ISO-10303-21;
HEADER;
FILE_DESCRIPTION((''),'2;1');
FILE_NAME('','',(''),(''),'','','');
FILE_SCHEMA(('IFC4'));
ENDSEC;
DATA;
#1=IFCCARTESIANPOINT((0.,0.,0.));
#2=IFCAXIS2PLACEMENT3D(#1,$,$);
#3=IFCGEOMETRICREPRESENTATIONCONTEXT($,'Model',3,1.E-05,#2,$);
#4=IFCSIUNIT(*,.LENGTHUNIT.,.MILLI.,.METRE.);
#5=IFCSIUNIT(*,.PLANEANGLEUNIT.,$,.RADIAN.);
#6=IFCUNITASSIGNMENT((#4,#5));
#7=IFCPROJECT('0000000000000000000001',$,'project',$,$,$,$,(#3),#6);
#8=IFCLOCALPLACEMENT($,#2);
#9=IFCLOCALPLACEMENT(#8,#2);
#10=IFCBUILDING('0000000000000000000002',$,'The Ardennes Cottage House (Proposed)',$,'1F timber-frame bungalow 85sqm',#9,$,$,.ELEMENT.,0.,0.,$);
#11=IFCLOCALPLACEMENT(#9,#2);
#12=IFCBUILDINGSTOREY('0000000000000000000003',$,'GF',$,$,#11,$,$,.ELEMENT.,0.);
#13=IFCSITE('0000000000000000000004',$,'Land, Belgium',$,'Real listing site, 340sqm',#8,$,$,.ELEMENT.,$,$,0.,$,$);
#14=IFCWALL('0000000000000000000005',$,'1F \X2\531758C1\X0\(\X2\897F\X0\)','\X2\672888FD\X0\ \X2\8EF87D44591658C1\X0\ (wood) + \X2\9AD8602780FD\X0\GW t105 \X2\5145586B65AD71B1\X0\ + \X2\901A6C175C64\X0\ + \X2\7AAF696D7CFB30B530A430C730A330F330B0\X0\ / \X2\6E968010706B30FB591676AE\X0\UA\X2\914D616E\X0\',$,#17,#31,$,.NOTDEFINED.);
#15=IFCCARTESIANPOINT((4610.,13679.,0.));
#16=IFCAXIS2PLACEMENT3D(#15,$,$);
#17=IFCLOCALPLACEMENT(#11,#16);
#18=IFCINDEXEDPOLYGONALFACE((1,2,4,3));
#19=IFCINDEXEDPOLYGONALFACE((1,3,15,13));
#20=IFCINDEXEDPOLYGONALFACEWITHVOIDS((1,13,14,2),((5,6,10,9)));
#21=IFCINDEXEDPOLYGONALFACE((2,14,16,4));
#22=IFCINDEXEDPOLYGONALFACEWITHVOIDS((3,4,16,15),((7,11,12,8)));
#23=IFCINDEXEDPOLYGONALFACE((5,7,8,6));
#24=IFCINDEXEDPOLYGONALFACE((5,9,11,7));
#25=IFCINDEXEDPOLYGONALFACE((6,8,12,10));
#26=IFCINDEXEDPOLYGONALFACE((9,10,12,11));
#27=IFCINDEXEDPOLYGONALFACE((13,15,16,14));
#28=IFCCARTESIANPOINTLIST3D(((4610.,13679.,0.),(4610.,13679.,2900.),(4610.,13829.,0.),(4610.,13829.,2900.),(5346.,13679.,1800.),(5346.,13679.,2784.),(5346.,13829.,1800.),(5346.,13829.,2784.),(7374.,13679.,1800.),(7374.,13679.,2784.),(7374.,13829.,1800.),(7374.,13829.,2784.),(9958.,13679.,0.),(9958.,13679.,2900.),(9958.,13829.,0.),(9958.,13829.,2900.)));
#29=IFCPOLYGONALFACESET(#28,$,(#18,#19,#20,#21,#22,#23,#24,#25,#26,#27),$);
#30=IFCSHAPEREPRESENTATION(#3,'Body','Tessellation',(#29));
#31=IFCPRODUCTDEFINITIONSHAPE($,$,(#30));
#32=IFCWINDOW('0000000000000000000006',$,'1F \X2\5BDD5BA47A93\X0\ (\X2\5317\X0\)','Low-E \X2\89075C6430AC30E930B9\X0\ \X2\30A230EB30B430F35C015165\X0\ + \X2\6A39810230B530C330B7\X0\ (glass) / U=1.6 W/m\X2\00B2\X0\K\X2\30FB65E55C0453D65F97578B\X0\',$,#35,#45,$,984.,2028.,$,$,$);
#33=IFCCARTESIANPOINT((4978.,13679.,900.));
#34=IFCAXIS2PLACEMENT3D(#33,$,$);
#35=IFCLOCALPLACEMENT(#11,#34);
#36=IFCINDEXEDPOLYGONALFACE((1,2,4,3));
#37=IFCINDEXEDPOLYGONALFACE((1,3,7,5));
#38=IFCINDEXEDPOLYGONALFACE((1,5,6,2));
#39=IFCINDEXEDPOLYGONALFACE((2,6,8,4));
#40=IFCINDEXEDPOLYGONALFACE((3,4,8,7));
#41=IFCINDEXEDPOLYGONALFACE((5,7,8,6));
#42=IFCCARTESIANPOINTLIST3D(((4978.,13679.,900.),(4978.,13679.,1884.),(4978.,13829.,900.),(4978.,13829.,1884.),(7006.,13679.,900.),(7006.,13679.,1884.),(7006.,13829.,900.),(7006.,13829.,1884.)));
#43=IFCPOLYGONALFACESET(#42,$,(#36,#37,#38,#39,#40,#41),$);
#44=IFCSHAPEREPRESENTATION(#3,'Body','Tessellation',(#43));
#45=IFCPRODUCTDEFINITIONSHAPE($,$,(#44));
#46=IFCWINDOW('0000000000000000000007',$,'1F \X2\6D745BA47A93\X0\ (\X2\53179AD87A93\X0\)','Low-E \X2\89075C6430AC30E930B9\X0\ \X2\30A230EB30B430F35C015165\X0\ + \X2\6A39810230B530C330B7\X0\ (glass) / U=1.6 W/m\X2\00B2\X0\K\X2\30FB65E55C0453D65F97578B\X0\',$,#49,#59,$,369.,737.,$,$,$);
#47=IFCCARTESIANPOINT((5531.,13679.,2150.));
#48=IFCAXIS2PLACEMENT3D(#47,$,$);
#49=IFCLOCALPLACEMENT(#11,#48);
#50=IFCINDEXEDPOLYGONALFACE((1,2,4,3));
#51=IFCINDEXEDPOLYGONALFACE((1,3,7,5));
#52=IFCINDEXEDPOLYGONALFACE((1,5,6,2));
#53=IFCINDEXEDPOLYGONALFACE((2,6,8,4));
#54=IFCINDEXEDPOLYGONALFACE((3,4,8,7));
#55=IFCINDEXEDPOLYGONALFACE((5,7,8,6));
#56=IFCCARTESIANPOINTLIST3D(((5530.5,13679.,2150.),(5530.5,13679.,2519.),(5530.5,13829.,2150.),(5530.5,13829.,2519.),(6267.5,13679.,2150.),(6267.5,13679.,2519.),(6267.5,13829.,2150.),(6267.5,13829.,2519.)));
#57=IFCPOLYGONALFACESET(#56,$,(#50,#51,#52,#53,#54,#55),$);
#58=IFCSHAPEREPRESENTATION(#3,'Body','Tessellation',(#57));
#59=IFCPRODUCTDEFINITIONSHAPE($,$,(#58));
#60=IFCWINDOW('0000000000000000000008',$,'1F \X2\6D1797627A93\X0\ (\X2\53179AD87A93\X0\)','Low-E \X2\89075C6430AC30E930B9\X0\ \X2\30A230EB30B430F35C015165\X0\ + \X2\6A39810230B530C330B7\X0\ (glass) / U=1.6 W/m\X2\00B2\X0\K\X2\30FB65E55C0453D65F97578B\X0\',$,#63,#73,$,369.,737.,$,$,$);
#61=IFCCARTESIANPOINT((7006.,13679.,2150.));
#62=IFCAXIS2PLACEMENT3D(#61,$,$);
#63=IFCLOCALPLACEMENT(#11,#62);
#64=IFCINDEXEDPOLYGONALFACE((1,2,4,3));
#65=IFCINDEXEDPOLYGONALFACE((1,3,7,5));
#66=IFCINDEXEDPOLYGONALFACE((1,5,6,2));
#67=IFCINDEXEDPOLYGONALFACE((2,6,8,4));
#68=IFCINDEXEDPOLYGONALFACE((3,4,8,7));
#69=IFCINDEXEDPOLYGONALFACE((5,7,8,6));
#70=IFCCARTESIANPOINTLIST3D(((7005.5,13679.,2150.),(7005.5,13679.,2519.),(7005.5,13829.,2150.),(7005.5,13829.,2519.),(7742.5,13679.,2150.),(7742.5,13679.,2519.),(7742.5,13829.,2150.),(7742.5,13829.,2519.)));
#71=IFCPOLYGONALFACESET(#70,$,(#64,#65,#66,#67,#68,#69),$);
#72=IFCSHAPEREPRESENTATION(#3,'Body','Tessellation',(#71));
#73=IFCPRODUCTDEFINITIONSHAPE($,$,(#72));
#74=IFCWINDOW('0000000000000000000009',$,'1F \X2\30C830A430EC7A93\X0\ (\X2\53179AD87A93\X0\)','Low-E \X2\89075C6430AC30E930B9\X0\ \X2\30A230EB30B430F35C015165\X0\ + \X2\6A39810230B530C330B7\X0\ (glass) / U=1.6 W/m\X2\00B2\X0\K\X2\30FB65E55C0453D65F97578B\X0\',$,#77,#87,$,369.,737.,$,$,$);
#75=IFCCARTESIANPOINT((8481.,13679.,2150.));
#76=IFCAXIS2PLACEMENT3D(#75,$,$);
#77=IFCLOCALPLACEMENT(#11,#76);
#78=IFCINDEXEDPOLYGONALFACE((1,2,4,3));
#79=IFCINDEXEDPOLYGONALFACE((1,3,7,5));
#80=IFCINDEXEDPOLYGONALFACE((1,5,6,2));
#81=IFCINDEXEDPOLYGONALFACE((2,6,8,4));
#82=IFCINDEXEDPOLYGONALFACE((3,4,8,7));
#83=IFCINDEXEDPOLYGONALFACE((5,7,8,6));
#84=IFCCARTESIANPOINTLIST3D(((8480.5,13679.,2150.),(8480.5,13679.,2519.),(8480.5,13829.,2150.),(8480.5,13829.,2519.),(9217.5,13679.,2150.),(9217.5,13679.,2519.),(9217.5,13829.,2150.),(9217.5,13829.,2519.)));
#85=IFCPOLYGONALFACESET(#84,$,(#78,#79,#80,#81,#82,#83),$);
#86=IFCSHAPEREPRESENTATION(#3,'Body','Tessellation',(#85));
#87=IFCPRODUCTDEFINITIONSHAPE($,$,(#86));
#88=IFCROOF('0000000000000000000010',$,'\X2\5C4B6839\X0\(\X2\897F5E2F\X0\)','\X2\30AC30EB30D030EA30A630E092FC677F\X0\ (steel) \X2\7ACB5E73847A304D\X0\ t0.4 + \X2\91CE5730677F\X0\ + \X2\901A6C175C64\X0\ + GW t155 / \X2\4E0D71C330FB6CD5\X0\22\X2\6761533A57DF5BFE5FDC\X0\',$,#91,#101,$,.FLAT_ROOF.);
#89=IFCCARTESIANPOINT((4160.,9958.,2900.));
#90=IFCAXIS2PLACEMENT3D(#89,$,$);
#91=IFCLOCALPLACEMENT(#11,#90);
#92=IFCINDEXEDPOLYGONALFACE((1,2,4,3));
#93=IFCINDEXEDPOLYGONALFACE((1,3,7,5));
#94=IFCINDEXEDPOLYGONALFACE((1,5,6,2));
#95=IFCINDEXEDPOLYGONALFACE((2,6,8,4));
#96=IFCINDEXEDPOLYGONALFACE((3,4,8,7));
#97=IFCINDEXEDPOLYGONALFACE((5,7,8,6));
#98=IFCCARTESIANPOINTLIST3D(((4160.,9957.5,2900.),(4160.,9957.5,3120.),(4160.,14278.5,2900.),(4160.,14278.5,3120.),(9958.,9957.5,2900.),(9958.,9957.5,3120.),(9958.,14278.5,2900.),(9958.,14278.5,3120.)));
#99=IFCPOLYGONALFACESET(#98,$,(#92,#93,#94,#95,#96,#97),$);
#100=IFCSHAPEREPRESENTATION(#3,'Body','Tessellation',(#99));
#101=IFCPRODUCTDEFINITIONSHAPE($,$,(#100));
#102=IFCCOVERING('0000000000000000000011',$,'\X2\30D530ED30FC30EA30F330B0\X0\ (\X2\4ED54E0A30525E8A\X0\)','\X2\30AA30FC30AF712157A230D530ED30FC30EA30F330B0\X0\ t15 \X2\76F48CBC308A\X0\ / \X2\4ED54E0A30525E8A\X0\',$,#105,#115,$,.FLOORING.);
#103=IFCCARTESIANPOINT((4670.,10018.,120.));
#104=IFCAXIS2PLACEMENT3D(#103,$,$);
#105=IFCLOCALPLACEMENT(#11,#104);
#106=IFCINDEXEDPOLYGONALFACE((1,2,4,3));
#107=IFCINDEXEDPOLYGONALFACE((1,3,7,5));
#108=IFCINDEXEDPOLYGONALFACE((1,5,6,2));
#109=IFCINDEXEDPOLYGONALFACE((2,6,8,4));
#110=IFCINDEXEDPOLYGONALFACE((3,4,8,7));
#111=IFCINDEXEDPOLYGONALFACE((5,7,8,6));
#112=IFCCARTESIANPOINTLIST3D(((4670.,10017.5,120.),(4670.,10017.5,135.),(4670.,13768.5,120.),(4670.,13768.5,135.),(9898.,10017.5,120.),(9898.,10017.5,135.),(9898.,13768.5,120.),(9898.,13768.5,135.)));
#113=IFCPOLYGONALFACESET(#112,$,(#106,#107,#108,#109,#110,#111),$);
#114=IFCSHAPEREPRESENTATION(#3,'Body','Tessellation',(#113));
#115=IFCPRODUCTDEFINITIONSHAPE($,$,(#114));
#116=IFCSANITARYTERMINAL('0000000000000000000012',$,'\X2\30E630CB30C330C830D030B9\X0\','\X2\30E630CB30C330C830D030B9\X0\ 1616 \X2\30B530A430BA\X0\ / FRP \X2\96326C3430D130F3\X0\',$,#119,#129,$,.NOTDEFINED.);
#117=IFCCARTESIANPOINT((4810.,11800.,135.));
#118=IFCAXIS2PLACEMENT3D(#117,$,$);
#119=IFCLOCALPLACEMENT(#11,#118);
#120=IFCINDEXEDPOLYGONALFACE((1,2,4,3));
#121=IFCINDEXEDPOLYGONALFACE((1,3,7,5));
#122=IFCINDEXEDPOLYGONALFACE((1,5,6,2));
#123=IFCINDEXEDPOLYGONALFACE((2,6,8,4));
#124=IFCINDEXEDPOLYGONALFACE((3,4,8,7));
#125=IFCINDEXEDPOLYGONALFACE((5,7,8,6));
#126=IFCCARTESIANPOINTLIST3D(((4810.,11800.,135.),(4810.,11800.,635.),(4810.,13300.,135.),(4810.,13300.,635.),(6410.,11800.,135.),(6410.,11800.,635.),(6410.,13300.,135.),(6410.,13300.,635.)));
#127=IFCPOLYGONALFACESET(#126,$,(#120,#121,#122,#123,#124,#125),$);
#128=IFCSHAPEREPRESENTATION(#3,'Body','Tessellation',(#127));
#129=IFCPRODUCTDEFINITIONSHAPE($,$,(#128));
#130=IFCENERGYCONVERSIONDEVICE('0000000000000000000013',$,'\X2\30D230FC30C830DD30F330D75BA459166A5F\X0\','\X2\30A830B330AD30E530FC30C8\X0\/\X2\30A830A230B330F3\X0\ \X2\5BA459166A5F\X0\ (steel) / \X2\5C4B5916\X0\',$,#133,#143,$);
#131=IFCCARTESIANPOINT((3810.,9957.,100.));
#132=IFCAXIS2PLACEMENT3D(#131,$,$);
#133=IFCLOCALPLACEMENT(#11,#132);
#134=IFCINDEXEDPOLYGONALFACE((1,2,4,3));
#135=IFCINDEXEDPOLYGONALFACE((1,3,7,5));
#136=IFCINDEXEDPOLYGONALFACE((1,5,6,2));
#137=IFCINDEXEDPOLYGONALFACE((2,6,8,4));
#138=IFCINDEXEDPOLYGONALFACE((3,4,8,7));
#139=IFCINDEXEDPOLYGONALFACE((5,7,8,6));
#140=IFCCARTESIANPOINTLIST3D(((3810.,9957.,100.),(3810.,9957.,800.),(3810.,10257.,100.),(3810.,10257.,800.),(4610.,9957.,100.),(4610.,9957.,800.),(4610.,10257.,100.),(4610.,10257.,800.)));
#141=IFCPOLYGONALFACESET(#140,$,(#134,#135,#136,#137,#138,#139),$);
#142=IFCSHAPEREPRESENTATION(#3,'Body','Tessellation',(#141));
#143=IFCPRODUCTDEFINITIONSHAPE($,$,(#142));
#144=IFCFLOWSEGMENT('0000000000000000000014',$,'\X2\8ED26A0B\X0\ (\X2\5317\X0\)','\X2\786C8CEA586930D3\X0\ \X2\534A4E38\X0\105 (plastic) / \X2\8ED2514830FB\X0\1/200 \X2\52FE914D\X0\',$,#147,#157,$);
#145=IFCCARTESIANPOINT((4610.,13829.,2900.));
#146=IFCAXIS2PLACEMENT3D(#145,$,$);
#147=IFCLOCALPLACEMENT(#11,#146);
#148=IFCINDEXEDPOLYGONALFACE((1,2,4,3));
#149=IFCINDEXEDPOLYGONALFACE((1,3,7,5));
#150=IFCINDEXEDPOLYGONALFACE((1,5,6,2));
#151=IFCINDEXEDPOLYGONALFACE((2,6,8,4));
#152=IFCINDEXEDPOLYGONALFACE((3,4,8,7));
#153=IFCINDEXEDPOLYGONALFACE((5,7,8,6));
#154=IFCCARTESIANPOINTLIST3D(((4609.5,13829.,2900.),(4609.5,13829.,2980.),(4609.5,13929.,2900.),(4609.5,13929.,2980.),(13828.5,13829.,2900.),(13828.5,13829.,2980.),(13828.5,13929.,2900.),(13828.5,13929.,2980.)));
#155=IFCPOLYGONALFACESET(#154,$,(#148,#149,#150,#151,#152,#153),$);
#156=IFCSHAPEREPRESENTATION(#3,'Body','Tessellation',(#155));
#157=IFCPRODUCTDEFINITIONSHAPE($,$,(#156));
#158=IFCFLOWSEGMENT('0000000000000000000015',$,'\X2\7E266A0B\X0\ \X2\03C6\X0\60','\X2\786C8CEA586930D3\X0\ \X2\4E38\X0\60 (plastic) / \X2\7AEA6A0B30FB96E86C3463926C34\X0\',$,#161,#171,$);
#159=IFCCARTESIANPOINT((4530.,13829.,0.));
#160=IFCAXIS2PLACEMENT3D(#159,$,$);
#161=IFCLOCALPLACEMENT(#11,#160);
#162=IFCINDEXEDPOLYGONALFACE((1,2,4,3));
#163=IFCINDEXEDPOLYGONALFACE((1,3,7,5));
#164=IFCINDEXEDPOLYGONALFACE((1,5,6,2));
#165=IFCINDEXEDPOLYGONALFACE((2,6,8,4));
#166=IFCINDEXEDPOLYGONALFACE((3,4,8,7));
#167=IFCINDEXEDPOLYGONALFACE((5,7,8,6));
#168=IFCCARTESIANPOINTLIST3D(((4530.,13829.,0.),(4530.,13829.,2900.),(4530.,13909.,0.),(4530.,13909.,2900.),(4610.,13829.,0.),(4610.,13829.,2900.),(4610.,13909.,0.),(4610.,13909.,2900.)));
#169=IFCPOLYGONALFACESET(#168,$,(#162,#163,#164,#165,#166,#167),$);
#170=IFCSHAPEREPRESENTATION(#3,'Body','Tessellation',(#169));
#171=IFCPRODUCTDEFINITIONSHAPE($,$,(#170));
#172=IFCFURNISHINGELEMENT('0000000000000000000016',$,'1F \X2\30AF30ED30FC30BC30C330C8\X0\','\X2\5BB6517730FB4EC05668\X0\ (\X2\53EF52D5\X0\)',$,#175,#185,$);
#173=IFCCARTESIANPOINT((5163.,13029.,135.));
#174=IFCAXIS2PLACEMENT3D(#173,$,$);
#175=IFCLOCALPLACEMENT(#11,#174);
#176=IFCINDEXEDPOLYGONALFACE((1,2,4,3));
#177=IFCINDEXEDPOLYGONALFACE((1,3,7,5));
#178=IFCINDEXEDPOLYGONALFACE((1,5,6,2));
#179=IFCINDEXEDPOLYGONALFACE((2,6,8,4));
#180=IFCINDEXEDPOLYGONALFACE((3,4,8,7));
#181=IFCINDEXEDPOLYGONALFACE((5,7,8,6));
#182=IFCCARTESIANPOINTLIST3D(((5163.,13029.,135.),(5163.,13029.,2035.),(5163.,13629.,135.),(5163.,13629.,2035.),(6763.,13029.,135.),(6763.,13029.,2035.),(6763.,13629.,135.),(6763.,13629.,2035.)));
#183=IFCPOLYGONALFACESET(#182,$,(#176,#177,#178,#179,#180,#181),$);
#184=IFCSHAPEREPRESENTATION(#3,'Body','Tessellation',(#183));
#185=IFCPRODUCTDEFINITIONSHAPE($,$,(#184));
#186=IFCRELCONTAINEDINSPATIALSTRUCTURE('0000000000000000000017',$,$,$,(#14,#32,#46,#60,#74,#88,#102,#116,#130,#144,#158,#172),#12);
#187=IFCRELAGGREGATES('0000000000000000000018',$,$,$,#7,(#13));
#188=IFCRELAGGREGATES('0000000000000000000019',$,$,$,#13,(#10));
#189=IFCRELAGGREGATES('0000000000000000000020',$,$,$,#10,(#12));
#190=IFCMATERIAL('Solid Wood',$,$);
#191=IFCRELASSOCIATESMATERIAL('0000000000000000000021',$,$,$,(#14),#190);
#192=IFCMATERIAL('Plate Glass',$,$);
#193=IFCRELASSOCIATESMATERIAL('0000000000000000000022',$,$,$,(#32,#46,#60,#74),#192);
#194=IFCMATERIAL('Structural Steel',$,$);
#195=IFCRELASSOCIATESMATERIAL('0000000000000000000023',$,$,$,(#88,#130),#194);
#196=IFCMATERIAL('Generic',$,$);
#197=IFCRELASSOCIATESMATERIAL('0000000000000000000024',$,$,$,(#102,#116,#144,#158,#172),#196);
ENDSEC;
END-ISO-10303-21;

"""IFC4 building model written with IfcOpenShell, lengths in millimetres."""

from ifc_helpers import new_model, si_unit, frame, frame_2d, origin, place, context, project, spatial, rectangle, extrude, material, element, fill, save


model = new_model("IFC4")

# Units and contexts
model_context = context("Model", 3, precision=1e-05, world=origin())
ifc_project = project(units=[si_unit("LENGTHUNIT", "METRE", prefix="MILLI"), si_unit("PLANEANGLEUNIT", "RADIAN")], contexts=[model_context])

# Site, building, storey
site_placement = place(None, origin())
site = spatial("IfcSite", under=ifc_project, at=site_placement, Name="Land, Belgium", ObjectType="Real listing site, 340sqm", CompositionType="ELEMENT", RefElevation=0.0)
building_placement = place(site_placement, origin())
building = spatial("IfcBuilding", under=site, at=building_placement, Name="The Ardennes Cottage House (Proposed)", ObjectType="1F timber-frame bungalow 85sqm", CompositionType="ELEMENT", ElevationOfRefHeight=0.0, ElevationOfTerrain=0.0)
storey_placement = place(building_placement, origin())
storey = spatial("IfcBuildingStorey", under=building, at=storey_placement, Name="GF", CompositionType="ELEMENT", Elevation=0.0)

# Shared definitions
ifc_material_1 = material(Name="Solid Wood")

# Wall, openings, windows
wall_1_placement = place(storey_placement, frame((4610.0, 13679.0, 0.0)))
wall_1 = element("IfcWall", 1, at=wall_1_placement, inside=storey, material=ifc_material_1, Name="1F 北壁(西)", Description="木製 軸組外壁 (wood) + 高性能GW t105 充填断熱 + 通気層 + 窯業系サイディング / 準耐火・外皮UA配慮", PredefinedType="NOTDEFINED", context=model_context, shape_type="SweptSolid", body=[
    extrude(rectangle(XDim=5348.0, YDim=150.0, at=frame_2d((2674.0, 75.0))), frame((4610.0, 13679.0, 0.0)), (0.0, 0.0, 1.0), 2900.0),
])
opening_1_placement = place(storey_placement, frame((4978.0, 13679.0, 900.0)))
opening_1 = element("IfcOpeningElement", 2, at=opening_1_placement, cuts=wall_1, PredefinedType="NOTDEFINED", context=model_context, shape_type="SweptSolid", body=[
    extrude(rectangle(XDim=2028.0, YDim=150.0, at=frame_2d((1014.0, 75.0))), frame((4978.0, 13679.0, 900.0)), (0.0, 0.0, 1.0), 984.0),
])
opening_2_placement = place(storey_placement, frame((5531.0, 13679.0, 2150.0)))
opening_2 = element("IfcOpeningElement", 3, at=opening_2_placement, cuts=wall_1, PredefinedType="NOTDEFINED", context=model_context, shape_type="SweptSolid", body=[
    extrude(rectangle(XDim=737.0, YDim=150.0, at=frame_2d((368.0, 75.0))), frame((5531.0, 13679.0, 2150.0)), (0.0, 0.0, 1.0), 369.0),
])
opening_3_placement = place(storey_placement, frame((7006.0, 13679.0, 2150.0)))
opening_3 = element("IfcOpeningElement", 4, at=opening_3_placement, cuts=wall_1, PredefinedType="NOTDEFINED", context=model_context, shape_type="SweptSolid", body=[
    extrude(rectangle(XDim=737.0, YDim=150.0, at=frame_2d((368.0, 75.0))), frame((7006.0, 13679.0, 2150.0)), (0.0, 0.0, 1.0), 369.0),
])
opening_4_placement = place(storey_placement, frame((8481.0, 13679.0, 2150.0)))
opening_4 = element("IfcOpeningElement", 5, at=opening_4_placement, cuts=wall_1, PredefinedType="NOTDEFINED", context=model_context, shape_type="SweptSolid", body=[
    extrude(rectangle(XDim=737.0, YDim=150.0, at=frame_2d((368.0, 75.0))), frame((8481.0, 13679.0, 2150.0)), (0.0, 0.0, 1.0), 369.0),
])
ifc_material_2 = material(Name="Plate Glass")
window_1_placement = place(storey_placement, frame((4978.0, 13679.0, 900.0)))
window_1 = element("IfcWindow", 6, at=window_1_placement, inside=storey, material=ifc_material_2, Name="1F 寝室窓 (北)", Description="Low-E 複層ガラス アルゴン封入 + 樹脂サッシ (glass) / U=1.6 W/m²K・日射取得型", OverallHeight=984.0, OverallWidth=2028.0, context=model_context, shape_type="SweptSolid", body=[
    extrude(rectangle(XDim=2028.0, YDim=150.0, at=frame_2d((1014.0, 75.0))), frame((4978.0, 13679.0, 900.0)), (0.0, 0.0, 1.0), 984.0),
])
fill(opening_1, window_1)
window_2_placement = place(storey_placement, frame((5531.0, 13679.0, 2150.0)))
window_2 = element("IfcWindow", 7, at=window_2_placement, inside=storey, material=ifc_material_2, Name="1F 浴室窓 (北高窓)", Description="Low-E 複層ガラス アルゴン封入 + 樹脂サッシ (glass) / U=1.6 W/m²K・日射取得型", OverallHeight=369.0, OverallWidth=737.0, context=model_context, shape_type="SweptSolid", body=[
    extrude(rectangle(XDim=737.0, YDim=150.0, at=frame_2d((368.0, 75.0))), frame((5531.0, 13679.0, 2150.0)), (0.0, 0.0, 1.0), 369.0),
])
fill(opening_2, window_2)
window_3_placement = place(storey_placement, frame((7006.0, 13679.0, 2150.0)))
window_3 = element("IfcWindow", 8, at=window_3_placement, inside=storey, material=ifc_material_2, Name="1F 洗面窓 (北高窓)", Description="Low-E 複層ガラス アルゴン封入 + 樹脂サッシ (glass) / U=1.6 W/m²K・日射取得型", OverallHeight=369.0, OverallWidth=737.0, context=model_context, shape_type="SweptSolid", body=[
    extrude(rectangle(XDim=737.0, YDim=150.0, at=frame_2d((368.0, 75.0))), frame((7006.0, 13679.0, 2150.0)), (0.0, 0.0, 1.0), 369.0),
])
fill(opening_3, window_3)
window_4_placement = place(storey_placement, frame((8481.0, 13679.0, 2150.0)))
window_4 = element("IfcWindow", 9, at=window_4_placement, inside=storey, material=ifc_material_2, Name="1F トイレ窓 (北高窓)", Description="Low-E 複層ガラス アルゴン封入 + 樹脂サッシ (glass) / U=1.6 W/m²K・日射取得型", OverallHeight=369.0, OverallWidth=737.0, context=model_context, shape_type="SweptSolid", body=[
    extrude(rectangle(XDim=737.0, YDim=150.0, at=frame_2d((368.0, 75.0))), frame((8481.0, 13679.0, 2150.0)), (0.0, 0.0, 1.0), 369.0),
])
fill(opening_4, window_4)

# Roof
ifc_material_3 = material(Name="Structural Steel")
roof_placement = place(storey_placement, frame((4160.0, 9958.0, 2900.0)))
element("IfcRoof", 10, at=roof_placement, inside=storey, material=ifc_material_3, Name="屋根(西帯)", Description="ガルバリウム鋼板 (steel) 立平葺き t0.4 + 野地板 + 通気層 + GW t155 / 不燃・法22条区域対応", PredefinedType="FLAT_ROOF", context=model_context, shape_type="SweptSolid", body=[
    extrude(rectangle(XDim=5798.0, YDim=4321.0, at=frame_2d((2899.0, 2160.0))), frame((4160.0, 9958.0, 2900.0)), (0.0, 0.0, 1.0), 220.0),
])

# Covering
ifc_material_4 = material(Name="Generic")
covering_placement = place(storey_placement, frame((4670.0, 10018.0, 120.0)))
element("IfcCovering", 11, at=covering_placement, inside=storey, material=ifc_material_4, Name="フローリング (仕上げ床)", Description="オーク無垢フローリング t15 直貼り / 仕上げ床", PredefinedType="FLOORING", context=model_context, shape_type="SweptSolid", body=[
    extrude(rectangle(XDim=5228.0, YDim=3751.0, at=frame_2d((2614.0, 1875.0))), frame((4670.0, 10018.0, 120.0)), (0.0, 0.0, 1.0), 15.0),
])

# Sanitary terminal
sanitary_terminal_placement = place(storey_placement, frame((4810.0, 11800.0, 135.0)))
element("IfcSanitaryTerminal", 12, at=sanitary_terminal_placement, inside=storey, material=ifc_material_4, Name="ユニットバス", Description="ユニットバス 1616 サイズ / FRP 防水パン", PredefinedType="NOTDEFINED", context=model_context, shape_type="SweptSolid", body=[
    extrude(rectangle(XDim=1600.0, YDim=1500.0, at=frame_2d((800.0, 750.0))), frame((4810.0, 11800.0, 135.0)), (0.0, 0.0, 1.0), 500.0),
])

# Energy conversion device
energy_conversion_device_placement = place(storey_placement, frame((3810.0, 9957.0, 100.0)))
element("IfcEnergyConversionDevice", 13, at=energy_conversion_device_placement, inside=storey, material=ifc_material_3, Name="ヒートポンプ室外機", Description="エコキュート/エアコン 室外機 (steel) / 屋外", context=model_context, shape_type="SweptSolid", body=[
    extrude(rectangle(XDim=800.0, YDim=300.0, at=frame_2d((400.0, 150.0))), frame((3810.0, 9957.0, 100.0)), (0.0, 0.0, 1.0), 700.0),
])

# Flow segments
flow_segment_1_placement = place(storey_placement, frame((4610.0, 13829.0, 2900.0)))
element("IfcFlowSegment", 14, at=flow_segment_1_placement, inside=storey, material=ifc_material_4, Name="軒樋 (北)", Description="硬質塩ビ 半丸105 (plastic) / 軒先・1/200 勾配", context=model_context, shape_type="SweptSolid", body=[
    extrude(rectangle(XDim=9219.0, YDim=100.0, at=frame_2d((4609.0, 50.0))), frame((4610.0, 13829.0, 2900.0)), (0.0, 0.0, 1.0), 80.0),
])
flow_segment_2_placement = place(storey_placement, frame((4530.0, 13829.0, 0.0)))
element("IfcFlowSegment", 15, at=flow_segment_2_placement, inside=storey, material=ifc_material_4, Name="縦樋 φ60", Description="硬質塩ビ 丸60 (plastic) / 竪樋・雨水排水", context=model_context, shape_type="SweptSolid", body=[
    extrude(rectangle(XDim=80.0, YDim=80.0, at=frame_2d((40.0, 40.0))), frame((4530.0, 13829.0, 0.0)), (0.0, 0.0, 1.0), 2900.0),
])

# Furnishing element
furnishing_1_placement = place(storey_placement, frame((5163.0, 13029.0, 135.0)))
element("IfcFurnishingElement", 16, at=furnishing_1_placement, inside=storey, material=ifc_material_4, Name="1F クローゼット", Description="家具・什器 (可動)", context=model_context, shape_type="SweptSolid", body=[
    extrude(rectangle(XDim=1600.0, YDim=600.0, at=frame_2d((800.0, 300.0))), frame((5163.0, 13029.0, 135.0)), (0.0, 0.0, 1.0), 1900.0),
])

save(model, "model.ifc")
